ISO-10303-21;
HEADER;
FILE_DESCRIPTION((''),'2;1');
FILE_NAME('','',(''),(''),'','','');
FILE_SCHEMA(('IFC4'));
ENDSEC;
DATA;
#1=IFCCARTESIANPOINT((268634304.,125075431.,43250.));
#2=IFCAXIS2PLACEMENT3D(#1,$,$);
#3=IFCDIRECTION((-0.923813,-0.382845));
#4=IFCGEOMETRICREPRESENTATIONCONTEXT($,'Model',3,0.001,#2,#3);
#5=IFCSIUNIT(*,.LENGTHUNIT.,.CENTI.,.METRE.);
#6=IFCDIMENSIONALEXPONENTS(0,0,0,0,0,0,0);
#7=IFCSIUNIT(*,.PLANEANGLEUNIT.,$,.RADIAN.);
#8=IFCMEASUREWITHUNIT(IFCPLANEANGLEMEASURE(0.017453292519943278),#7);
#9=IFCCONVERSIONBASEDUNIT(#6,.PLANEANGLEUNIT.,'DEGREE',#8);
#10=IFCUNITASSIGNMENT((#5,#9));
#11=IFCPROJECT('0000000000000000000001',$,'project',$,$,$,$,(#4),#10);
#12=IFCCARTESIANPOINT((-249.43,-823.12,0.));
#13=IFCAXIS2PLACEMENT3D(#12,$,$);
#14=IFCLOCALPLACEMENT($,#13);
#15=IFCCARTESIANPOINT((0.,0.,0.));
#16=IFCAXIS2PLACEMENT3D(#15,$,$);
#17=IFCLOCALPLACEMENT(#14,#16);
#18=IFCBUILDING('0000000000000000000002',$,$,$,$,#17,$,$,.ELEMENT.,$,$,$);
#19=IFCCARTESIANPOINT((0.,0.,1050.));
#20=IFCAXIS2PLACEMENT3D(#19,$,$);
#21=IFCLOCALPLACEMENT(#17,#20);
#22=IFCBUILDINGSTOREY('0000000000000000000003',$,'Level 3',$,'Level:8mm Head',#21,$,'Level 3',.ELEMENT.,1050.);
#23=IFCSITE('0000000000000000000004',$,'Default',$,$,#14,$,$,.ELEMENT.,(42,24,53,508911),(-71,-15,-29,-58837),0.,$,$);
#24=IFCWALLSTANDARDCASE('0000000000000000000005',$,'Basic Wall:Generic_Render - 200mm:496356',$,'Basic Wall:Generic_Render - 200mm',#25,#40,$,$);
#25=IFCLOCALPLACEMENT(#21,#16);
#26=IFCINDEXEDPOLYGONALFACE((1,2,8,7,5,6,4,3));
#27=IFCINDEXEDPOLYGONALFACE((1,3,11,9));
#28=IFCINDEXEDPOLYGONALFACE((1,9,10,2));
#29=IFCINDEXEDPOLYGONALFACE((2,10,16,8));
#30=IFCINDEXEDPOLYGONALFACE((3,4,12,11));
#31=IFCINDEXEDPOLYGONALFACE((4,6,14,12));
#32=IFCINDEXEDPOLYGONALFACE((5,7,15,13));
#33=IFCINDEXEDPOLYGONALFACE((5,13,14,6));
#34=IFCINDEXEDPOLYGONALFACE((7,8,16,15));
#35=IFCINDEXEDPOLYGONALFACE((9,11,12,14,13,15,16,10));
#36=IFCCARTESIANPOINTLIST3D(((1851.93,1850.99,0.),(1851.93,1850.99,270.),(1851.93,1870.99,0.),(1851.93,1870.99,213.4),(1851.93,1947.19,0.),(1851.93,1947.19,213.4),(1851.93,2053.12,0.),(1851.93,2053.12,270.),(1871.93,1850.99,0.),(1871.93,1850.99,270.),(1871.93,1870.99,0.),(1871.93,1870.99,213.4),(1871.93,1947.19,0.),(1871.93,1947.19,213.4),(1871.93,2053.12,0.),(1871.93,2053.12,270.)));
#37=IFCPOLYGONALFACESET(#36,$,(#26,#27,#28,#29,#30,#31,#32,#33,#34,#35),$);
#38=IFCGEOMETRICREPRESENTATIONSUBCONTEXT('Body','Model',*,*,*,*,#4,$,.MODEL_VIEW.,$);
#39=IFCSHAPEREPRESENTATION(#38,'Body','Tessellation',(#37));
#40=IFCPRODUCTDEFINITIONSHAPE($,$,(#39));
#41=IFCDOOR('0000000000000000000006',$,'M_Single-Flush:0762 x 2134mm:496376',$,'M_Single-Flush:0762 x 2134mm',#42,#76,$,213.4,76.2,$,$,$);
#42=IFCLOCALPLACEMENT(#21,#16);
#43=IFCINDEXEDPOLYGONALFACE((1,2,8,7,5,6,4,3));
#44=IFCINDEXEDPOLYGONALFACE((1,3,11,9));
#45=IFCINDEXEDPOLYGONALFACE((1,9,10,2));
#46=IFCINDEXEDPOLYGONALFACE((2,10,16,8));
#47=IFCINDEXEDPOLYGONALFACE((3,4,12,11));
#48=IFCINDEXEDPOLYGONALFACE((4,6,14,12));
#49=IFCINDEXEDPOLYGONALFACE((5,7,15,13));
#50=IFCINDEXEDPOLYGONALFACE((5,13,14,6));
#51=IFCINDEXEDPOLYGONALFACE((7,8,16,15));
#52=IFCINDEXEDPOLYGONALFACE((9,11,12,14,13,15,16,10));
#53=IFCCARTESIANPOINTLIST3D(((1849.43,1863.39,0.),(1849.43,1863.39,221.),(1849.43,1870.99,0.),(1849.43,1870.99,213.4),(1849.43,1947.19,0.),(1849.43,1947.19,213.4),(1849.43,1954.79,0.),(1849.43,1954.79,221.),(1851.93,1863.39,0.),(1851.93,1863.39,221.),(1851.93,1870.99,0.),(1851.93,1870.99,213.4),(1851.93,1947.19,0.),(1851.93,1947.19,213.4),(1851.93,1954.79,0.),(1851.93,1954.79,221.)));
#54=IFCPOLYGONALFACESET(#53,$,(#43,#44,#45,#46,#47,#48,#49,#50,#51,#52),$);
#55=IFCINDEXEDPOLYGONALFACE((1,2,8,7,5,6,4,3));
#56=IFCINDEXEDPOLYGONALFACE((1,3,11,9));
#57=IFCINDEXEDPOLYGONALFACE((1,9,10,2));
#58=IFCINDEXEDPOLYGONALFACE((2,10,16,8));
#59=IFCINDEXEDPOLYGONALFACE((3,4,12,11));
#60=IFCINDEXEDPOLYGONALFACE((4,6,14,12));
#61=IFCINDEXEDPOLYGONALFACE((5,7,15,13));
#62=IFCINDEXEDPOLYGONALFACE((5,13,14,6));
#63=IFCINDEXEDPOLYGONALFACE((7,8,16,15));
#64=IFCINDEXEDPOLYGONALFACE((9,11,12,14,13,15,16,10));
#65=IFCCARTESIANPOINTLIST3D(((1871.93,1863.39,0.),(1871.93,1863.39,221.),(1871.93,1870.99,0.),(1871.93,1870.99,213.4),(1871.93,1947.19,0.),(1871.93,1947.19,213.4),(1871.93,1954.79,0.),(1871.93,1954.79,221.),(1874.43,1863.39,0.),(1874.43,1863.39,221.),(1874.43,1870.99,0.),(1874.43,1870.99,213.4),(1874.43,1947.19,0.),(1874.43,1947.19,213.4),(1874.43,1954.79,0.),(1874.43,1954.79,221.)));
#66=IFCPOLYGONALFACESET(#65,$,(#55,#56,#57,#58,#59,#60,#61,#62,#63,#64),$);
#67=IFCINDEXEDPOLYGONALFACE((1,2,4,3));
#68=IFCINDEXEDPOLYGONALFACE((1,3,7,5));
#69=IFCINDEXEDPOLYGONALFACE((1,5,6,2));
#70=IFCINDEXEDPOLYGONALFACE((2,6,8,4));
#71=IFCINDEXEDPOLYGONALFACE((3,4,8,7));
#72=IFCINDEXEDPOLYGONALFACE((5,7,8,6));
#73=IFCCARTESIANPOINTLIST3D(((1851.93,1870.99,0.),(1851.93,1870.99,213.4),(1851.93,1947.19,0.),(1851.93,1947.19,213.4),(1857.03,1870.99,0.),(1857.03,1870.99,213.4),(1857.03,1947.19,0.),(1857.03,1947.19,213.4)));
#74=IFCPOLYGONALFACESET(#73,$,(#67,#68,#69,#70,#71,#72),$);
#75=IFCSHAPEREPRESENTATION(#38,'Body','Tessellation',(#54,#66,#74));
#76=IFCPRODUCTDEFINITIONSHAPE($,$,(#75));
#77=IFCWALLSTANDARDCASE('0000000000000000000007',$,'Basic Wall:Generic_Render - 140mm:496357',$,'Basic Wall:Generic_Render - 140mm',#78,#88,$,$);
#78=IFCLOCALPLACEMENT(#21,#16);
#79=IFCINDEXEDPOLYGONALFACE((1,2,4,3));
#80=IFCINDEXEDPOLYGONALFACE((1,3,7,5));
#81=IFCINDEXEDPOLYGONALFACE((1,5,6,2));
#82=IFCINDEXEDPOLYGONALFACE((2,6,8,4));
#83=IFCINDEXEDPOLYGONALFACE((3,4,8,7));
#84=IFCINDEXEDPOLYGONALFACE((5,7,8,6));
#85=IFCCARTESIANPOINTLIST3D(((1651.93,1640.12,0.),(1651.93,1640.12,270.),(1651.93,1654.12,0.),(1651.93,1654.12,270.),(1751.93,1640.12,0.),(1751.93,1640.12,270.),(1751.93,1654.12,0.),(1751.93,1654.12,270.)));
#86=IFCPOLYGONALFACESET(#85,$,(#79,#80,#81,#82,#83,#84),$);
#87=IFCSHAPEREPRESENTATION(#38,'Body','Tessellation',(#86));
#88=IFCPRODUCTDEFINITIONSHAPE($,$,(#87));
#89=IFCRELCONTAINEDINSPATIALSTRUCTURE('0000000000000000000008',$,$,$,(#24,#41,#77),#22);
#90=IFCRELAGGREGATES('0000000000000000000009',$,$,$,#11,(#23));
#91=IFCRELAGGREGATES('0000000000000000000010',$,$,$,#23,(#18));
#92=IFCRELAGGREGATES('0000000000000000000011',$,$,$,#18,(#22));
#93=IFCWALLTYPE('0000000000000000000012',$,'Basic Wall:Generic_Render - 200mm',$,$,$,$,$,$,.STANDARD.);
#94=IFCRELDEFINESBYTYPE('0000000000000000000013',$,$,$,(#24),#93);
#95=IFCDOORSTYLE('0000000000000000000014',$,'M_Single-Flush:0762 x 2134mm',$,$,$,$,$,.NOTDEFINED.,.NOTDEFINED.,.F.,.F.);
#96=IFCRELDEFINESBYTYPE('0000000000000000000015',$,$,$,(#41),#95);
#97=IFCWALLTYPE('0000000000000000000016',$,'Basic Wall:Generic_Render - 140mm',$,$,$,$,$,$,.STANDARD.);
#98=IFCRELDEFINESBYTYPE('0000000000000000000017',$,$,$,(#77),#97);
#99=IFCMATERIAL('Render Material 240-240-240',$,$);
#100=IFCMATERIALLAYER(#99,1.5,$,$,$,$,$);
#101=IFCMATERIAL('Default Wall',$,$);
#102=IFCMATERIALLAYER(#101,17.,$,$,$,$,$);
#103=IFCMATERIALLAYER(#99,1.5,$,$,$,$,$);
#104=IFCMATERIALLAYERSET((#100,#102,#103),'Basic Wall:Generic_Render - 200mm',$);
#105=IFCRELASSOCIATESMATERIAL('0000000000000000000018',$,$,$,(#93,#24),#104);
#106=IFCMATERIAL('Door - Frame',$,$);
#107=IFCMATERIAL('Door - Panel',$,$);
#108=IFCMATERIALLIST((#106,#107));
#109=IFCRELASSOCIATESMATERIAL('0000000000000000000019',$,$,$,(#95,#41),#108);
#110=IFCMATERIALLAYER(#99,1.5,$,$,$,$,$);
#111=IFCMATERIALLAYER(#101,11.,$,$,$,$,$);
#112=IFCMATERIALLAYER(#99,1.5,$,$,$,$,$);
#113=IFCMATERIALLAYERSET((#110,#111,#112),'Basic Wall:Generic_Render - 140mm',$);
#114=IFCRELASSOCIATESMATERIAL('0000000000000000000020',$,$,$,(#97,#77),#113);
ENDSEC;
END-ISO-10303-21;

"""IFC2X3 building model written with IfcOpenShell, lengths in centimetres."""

from ifc_helpers import new_model, entity, si_unit, converted_unit, direction, frame, frame_2d, origin, place, context, subcontext, project, spatial, polyline, rectangle, outline, extrude, source, transform, mapped, material, material_list, layer, layer_set, layer_usage, type_object, type_shapes, element, fill, save


model = new_model("IFC2X3")

# Units and contexts
model_context = context("Model", 3, precision=0.001, world=frame((268634304.0, 125075431.0, 43250.0)), true_north=direction((-0.923813, -0.382845)))
body_context = subcontext(model_context, "Body", "Model", "MODEL_VIEW")
ifc_project = project(units=[si_unit("LENGTHUNIT", "METRE", prefix="CENTI"), converted_unit("PLANEANGLEUNIT", "DEGREE", entity("IfcPlaneAngleMeasure", 0.017453292519943278), si_unit("PLANEANGLEUNIT", "RADIAN"), dimensions=[0, 0, 0, 0, 0, 0, 0])], contexts=[model_context])

# Site, building, storey
site_placement = place(None, frame((-249.43, -823.12, 0.0)))
site = spatial("IfcSite", under=ifc_project, at=site_placement, Name="Default", CompositionType="ELEMENT", RefLatitude=(42, 24, 53, 508911), RefLongitude=(-71, -15, -29, -58837), RefElevation=0.0)
building_placement = place(site_placement, origin())
building = spatial("IfcBuilding", under=site, at=building_placement, CompositionType="ELEMENT")
storey_placement = place(building_placement, frame((0.0, 0.0, 1050.0)))
storey = spatial("IfcBuildingStorey", under=building, at=storey_placement, Name="Level 3", ObjectType="Level:8mm Head", LongName="Level 3", CompositionType="ELEMENT", Elevation=1050.0)

# Shared definitions
ifc_material_1 = material(Name="Render Material 240-240-240")
ifc_material_2 = material(Name="Default Wall")
ifc_layer_1 = layer(ifc_material_1, 1.5)
ifc_layer_2 = layer(ifc_material_2, 17.0)
ifc_layer_3 = layer(ifc_material_1, 1.5)
ifc_layer_set_1 = layer_set([ifc_layer_1, ifc_layer_2, ifc_layer_3], Name="Basic Wall:Generic_Render - 200mm")
wall_type_1 = type_object("IfcWallType", Name="Basic Wall:Generic_Render - 200mm", PredefinedType="STANDARD", material=ifc_layer_set_1)

# Shared definitions
ifc_material_3 = material(Name="Door - Frame")
ifc_material_4 = material(Name="Door - Panel")
ifc_material_list = material_list([ifc_material_3, ifc_material_4])

# Wall, opening, door
ifc_layer_usage_1 = layer_usage(ifc_layer_set_1, "AXIS2", "NEGATIVE", 10.0)
wall_1_placement = place(storey_placement, frame((1861.93, 1850.99, 0.0), z_axis=(0.0, 0.0, 1.0), x_axis=(0.0, 1.0, 0.0)))
wall_1 = element("IfcWallStandardCase", 1, at=wall_1_placement, inside=storey, type_object=wall_type_1, material=ifc_layer_usage_1, Name="Basic Wall:Generic_Render - 200mm:496356", ObjectType="Basic Wall:Generic_Render - 200mm", context=body_context, shape_type="SweptSolid", body=[
    extrude(rectangle(XDim=202.14, YDim=20.0, at=frame_2d((101.07, 0.0), x_axis=(1.0, 0.0))), origin(), (0.0, 0.0, 1.0), 270.0),
])
opening_1_placement = place(wall_1_placement, frame((20.0, -10.0, 0.0)))
opening_1 = element("IfcOpeningElement", 2, at=opening_1_placement, cuts=wall_1, ObjectType="Opening", context=body_context, shape_type="SweptSolid", body=[
    extrude(rectangle(XDim=76.2, YDim=213.4, at=frame_2d((106.7, 38.1), x_axis=(0.0, -1.0))), frame((0.0, 0.0, 0.0), z_axis=(0.0, 1.0, 0.0), x_axis=(0.0, 0.0, 1.0)), (0.0, 0.0, 1.0), 20.0),
])
door_style_1 = type_object("IfcDoorStyle", Name="M_Single-Flush:0762 x 2134mm", ConstructionType="NOTDEFINED", OperationType="NOTDEFINED", ParameterTakesPrecedence=False, Sizeable=False, material=ifc_material_list)
shared_shape_1 = source(origin(), body_context, "Body", "SweptSolid", [
    extrude(outline(polyline([(-45.7, -112.4), (45.7, -112.4), (45.7, 108.6), (38.1, 108.6), (38.1, -104.8), (-38.1, -104.8), (-38.1, 108.6), (-45.7, 108.6), (-45.7, -112.4)])), frame((38.1, 22.5, 108.6), z_axis=(0.0, -1.0, 0.0), x_axis=(-1.0, 0.0, 0.0)), (0.0, 0.0, 1.0), 2.5),
    extrude(outline(polyline([(-112.4, -45.7), (108.6, -45.7), (108.6, -38.1), (-104.8, -38.1), (-104.8, 38.1), (108.6, 38.1), (108.6, 45.7), (-112.4, 45.7), (-112.4, -45.7)])), frame((38.1, 0.0, 108.6), z_axis=(0.0, -1.0, 0.0), x_axis=(0.0, 0.0, -1.0)), (0.0, 0.0, 1.0), 2.5),
    extrude(rectangle(XDim=76.2, YDim=5.1, at=frame_2d((0.0, 0.0), x_axis=(1.0, 0.0))), frame((38.1, 17.45, 0.0)), (0.0, 0.0, 1.0), 213.4),
])
type_shapes(door_style_1, [shared_shape_1])
door_1_placement = place(opening_1_placement, origin())
door_1 = element("IfcDoor", 3, at=door_1_placement, inside=storey, type_object=door_style_1, material=ifc_material_list, Name="M_Single-Flush:0762 x 2134mm:496376", ObjectType="M_Single-Flush:0762 x 2134mm", OverallHeight=213.4, OverallWidth=76.2, context=body_context, shape_type="MappedRepresentation", body=[
    mapped(shared_shape_1, transform((0.0, 0.0, 0.0), scale=1.0)),
])
fill(opening_1, door_1)

# Wall
ifc_layer_4 = layer(ifc_material_1, 1.5)
ifc_layer_5 = layer(ifc_material_2, 11.0)
ifc_layer_6 = layer(ifc_material_1, 1.5)
ifc_layer_set_2 = layer_set([ifc_layer_4, ifc_layer_5, ifc_layer_6], Name="Basic Wall:Generic_Render - 140mm")
ifc_layer_usage_2 = layer_usage(ifc_layer_set_2, "AXIS2", "NEGATIVE", 7.0)
wall_type_2 = type_object("IfcWallType", Name="Basic Wall:Generic_Render - 140mm", PredefinedType="STANDARD", material=ifc_layer_set_2)
wall_2_placement = place(storey_placement, frame((1651.93, 1647.12, 0.0)))
element("IfcWallStandardCase", 4, at=wall_2_placement, inside=storey, type_object=wall_type_2, material=ifc_layer_usage_2, Name="Basic Wall:Generic_Render - 140mm:496357", ObjectType="Basic Wall:Generic_Render - 140mm", context=body_context, shape_type="SweptSolid", body=[
    extrude(rectangle(XDim=100.0, YDim=14.0, at=frame_2d((50.0, 0.0), x_axis=(-1.0, 0.0))), origin(), (0.0, 0.0, 1.0), 270.0),
])

save(model, "model.ifc")
